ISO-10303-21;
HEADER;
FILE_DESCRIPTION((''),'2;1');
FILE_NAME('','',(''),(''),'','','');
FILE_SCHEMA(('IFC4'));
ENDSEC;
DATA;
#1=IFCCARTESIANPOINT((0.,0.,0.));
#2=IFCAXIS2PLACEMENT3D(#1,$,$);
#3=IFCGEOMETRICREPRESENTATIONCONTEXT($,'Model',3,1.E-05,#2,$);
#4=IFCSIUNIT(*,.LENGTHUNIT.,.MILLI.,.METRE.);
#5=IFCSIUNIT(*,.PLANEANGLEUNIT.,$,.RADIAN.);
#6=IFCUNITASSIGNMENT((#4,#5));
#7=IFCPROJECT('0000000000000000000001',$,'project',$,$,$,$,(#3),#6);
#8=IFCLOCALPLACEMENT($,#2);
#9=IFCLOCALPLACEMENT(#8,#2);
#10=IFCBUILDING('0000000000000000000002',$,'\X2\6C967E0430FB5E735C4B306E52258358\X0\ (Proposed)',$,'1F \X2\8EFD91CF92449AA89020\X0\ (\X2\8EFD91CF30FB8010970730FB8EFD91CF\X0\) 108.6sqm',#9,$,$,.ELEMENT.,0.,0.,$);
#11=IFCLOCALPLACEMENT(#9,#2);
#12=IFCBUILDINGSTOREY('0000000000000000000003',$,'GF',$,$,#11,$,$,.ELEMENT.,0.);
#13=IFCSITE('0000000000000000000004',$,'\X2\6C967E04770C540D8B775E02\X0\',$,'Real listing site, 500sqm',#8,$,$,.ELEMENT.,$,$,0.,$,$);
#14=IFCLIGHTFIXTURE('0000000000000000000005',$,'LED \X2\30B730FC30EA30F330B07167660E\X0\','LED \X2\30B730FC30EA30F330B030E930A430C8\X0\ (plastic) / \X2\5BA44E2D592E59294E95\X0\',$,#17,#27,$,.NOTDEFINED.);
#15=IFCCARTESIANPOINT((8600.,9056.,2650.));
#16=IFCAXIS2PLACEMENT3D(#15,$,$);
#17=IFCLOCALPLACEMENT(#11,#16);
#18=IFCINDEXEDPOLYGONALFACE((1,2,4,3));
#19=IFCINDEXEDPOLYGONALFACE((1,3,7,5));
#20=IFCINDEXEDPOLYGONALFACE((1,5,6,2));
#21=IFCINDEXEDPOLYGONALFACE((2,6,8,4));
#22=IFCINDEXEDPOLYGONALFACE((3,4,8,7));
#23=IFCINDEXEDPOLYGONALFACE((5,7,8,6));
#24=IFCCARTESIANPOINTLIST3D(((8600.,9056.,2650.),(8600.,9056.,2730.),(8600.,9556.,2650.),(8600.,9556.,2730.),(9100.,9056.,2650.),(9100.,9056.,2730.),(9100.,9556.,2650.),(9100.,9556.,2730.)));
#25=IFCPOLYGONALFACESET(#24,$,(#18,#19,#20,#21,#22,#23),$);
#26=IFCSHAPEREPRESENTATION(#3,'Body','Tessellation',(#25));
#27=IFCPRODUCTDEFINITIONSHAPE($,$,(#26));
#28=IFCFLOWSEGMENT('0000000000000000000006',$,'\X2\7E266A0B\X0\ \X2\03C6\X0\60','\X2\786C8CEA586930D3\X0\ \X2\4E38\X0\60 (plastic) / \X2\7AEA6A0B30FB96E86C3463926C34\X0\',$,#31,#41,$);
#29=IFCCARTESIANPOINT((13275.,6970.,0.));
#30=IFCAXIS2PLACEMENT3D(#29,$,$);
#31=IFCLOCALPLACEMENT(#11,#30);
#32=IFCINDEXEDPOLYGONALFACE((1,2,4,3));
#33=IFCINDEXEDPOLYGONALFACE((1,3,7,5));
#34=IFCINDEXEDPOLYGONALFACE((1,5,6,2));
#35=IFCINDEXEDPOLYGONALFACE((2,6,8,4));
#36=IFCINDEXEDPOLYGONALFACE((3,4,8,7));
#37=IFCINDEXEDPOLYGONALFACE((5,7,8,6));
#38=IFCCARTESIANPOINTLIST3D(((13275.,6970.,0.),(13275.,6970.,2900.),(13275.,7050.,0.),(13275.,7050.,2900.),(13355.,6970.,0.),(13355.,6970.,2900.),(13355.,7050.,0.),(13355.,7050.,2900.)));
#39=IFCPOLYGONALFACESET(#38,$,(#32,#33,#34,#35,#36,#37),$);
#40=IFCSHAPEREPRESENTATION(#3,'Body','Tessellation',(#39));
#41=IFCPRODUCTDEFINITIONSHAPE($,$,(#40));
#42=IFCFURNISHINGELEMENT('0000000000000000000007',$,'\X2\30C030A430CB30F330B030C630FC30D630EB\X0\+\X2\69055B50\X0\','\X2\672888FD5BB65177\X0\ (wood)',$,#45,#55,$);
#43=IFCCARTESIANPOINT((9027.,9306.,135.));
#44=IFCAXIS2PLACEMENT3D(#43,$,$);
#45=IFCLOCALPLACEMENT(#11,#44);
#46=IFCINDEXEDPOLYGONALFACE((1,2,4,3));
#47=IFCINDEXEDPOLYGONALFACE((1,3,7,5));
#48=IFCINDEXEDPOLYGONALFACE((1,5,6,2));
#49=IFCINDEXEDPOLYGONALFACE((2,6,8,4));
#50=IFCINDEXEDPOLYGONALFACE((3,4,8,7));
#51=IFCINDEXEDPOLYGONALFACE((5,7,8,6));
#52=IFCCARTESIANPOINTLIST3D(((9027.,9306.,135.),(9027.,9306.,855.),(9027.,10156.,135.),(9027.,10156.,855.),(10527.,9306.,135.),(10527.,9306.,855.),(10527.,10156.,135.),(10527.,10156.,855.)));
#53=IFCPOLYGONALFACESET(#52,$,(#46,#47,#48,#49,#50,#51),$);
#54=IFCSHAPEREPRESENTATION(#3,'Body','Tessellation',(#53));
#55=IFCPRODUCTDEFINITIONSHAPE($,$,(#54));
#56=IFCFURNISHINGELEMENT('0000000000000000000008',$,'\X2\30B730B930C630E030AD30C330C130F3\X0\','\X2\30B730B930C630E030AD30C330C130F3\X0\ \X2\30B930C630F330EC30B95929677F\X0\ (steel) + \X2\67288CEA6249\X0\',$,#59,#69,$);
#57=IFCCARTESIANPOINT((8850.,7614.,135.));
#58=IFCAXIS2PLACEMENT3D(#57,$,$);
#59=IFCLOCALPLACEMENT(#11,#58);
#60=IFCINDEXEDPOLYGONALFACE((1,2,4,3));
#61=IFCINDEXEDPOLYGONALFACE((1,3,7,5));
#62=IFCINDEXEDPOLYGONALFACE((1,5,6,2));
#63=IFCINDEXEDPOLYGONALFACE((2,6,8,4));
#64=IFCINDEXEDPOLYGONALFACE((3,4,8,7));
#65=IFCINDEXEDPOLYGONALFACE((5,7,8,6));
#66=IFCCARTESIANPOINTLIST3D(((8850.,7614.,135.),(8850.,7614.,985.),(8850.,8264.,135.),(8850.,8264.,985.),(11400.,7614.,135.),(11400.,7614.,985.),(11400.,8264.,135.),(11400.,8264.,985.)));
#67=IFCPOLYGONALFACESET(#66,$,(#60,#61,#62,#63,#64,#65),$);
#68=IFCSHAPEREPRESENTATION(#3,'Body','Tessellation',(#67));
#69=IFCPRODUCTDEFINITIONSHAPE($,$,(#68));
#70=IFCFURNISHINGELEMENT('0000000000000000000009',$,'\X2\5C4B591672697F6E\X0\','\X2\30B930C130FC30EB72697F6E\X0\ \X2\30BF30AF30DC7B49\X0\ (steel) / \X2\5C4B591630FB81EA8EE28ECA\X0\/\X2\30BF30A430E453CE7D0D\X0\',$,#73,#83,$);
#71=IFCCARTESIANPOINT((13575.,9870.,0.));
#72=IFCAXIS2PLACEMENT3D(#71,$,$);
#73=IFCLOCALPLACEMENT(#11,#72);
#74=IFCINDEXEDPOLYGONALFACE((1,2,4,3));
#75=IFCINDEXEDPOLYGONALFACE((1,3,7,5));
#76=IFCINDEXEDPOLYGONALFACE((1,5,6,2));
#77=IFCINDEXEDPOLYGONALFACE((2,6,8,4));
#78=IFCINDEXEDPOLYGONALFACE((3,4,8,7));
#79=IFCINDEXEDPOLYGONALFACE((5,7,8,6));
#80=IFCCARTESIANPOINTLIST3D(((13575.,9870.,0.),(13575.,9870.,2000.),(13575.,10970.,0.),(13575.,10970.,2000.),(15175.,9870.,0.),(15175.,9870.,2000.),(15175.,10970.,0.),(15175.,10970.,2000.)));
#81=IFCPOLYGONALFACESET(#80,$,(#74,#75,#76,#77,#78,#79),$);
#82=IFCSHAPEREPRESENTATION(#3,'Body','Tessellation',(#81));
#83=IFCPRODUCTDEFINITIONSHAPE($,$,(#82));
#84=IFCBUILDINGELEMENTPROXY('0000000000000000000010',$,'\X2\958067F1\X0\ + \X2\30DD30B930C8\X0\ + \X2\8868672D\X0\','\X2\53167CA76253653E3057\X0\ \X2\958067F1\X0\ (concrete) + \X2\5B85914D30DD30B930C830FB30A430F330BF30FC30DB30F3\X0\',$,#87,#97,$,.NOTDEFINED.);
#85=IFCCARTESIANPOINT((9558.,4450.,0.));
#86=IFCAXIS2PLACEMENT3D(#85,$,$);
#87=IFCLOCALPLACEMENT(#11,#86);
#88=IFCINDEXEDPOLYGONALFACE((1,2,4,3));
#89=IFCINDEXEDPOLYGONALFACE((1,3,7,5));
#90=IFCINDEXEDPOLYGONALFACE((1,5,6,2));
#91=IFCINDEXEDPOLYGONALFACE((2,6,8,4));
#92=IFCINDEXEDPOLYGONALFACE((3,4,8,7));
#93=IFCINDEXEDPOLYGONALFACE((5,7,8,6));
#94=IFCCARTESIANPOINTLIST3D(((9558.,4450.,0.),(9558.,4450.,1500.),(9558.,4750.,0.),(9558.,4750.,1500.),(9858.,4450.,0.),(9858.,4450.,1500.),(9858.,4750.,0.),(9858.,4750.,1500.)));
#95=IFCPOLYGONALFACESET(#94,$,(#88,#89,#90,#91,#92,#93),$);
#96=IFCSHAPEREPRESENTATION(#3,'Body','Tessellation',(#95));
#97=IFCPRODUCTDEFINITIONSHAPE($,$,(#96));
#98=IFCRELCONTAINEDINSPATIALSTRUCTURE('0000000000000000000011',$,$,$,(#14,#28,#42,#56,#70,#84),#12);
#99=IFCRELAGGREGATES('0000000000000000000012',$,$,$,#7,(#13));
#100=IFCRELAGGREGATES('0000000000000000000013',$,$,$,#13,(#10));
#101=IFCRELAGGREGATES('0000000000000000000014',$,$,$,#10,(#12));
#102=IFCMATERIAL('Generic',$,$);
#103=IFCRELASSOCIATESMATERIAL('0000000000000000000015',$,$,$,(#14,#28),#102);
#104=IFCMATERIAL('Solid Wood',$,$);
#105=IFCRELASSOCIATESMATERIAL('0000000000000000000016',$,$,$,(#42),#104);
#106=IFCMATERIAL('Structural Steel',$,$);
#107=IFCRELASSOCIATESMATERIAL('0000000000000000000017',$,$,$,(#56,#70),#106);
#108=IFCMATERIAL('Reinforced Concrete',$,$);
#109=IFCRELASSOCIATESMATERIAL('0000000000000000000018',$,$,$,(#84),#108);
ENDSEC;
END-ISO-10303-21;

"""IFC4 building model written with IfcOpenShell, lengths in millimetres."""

from ifc_helpers import new_model, si_unit, frame, frame_2d, origin, place, context, project, spatial, rectangle, extrude, material, element, save


model = new_model("IFC4")

# Units and contexts
model_context = context("Model", 3, precision=1e-05, world=origin())
ifc_project = project(units=[si_unit("LENGTHUNIT", "METRE", prefix="MILLI"), si_unit("PLANEANGLEUNIT", "RADIAN")], contexts=[model_context])

# Site, building, storey
site_placement = place(None, origin())
site = spatial("IfcSite", under=ifc_project, at=site_placement, Name="沖縄県名護市", ObjectType="Real listing site, 500sqm", CompositionType="ELEMENT", RefElevation=0.0)
building_placement = place(site_placement, origin())
building = spatial("IfcBuilding", under=site, at=building_placement, Name="沖縄・平屋の別荘 (Proposed)", ObjectType="1F 軽量鉄骨造 (軽量・耐震・軽量) 108.6sqm", CompositionType="ELEMENT", ElevationOfRefHeight=0.0, ElevationOfTerrain=0.0)
storey_placement = place(building_placement, origin())
storey = spatial("IfcBuildingStorey", under=building, at=storey_placement, Name="GF", CompositionType="ELEMENT", Elevation=0.0)

# Shared definitions
ifc_material_1 = material(Name="Solid Wood")

# Shared definitions
ifc_material_2 = material(Name="Structural Steel")

# Shared definitions
ifc_material_3 = material(Name="Reinforced Concrete")

# Shared definitions
ifc_material_4 = material(Name="Generic")

# Light fixture
light_fixture_placement = place(storey_placement, frame((8600.0, 9056.0, 2650.0)))
element("IfcLightFixture", 1, at=light_fixture_placement, inside=storey, material=ifc_material_4, Name="LED シーリング照明", Description="LED シーリングライト (plastic) / 室中央天井", PredefinedType="NOTDEFINED", context=model_context, shape_type="SweptSolid", body=[
    extrude(rectangle(XDim=500.0, YDim=500.0, at=frame_2d((250.0, 250.0))), frame((8600.0, 9056.0, 2650.0)), (0.0, 0.0, 1.0), 80.0),
])

# Flow segment
flow_segment_placement = place(storey_placement, frame((13275.0, 6970.0, 0.0)))
element("IfcFlowSegment", 2, at=flow_segment_placement, inside=storey, material=ifc_material_4, Name="縦樋 φ60", Description="硬質塩ビ 丸60 (plastic) / 竪樋・雨水排水", context=model_context, shape_type="SweptSolid", body=[
    extrude(rectangle(XDim=80.0, YDim=80.0, at=frame_2d((40.0, 40.0))), frame((13275.0, 6970.0, 0.0)), (0.0, 0.0, 1.0), 2900.0),
])

# Furnishing elements
furnishing_1_placement = place(storey_placement, frame((9027.0, 9306.0, 135.0)))
element("IfcFurnishingElement", 3, at=furnishing_1_placement, inside=storey, material=ifc_material_1, Name="ダイニングテーブル+椅子", Description="木製家具 (wood)", context=model_context, shape_type="SweptSolid", body=[
    extrude(rectangle(XDim=1500.0, YDim=850.0, at=frame_2d((750.0, 425.0))), frame((9027.0, 9306.0, 135.0)), (0.0, 0.0, 1.0), 720.0),
])
furnishing_2_placement = place(storey_placement, frame((8850.0, 7614.0, 135.0)))
element("IfcFurnishingElement", 4, at=furnishing_2_placement, inside=storey, material=ifc_material_2, Name="システムキッチン", Description="システムキッチン ステンレス天板 (steel) + 木質扉", context=model_context, shape_type="SweptSolid", body=[
    extrude(rectangle(XDim=2550.0, YDim=650.0, at=frame_2d((1275.0, 325.0))), frame((8850.0, 7614.0, 135.0)), (0.0, 0.0, 1.0), 850.0),
])
furnishing_3_placement = place(storey_placement, frame((13575.0, 9870.0, 0.0)))
element("IfcFurnishingElement", 5, at=furnishing_3_placement, inside=storey, material=ifc_material_2, Name="屋外物置", Description="スチール物置 タクボ等 (steel) / 屋外・自転車/タイヤ収納", context=model_context, shape_type="SweptSolid", body=[
    extrude(rectangle(XDim=1600.0, YDim=1100.0, at=frame_2d((800.0, 550.0))), frame((13575.0, 9870.0, 0.0)), (0.0, 0.0, 1.0), 2000.0),
])

# Building element proxy
proxy_placement = place(storey_placement, frame((9558.0, 4450.0, 0.0)))
element("IfcBuildingElementProxy", 6, at=proxy_placement, inside=storey, material=ifc_material_3, Name="門柱 + ポスト + 表札", Description="化粧打放し 門柱 (concrete) + 宅配ポスト・インターホン", PredefinedType="NOTDEFINED", context=model_context, shape_type="SweptSolid", body=[
    extrude(rectangle(XDim=300.0, YDim=300.0, at=frame_2d((150.0, 150.0))), frame((9558.0, 4450.0, 0.0)), (0.0, 0.0, 1.0), 1500.0),
])

save(model, "model.ifc")
